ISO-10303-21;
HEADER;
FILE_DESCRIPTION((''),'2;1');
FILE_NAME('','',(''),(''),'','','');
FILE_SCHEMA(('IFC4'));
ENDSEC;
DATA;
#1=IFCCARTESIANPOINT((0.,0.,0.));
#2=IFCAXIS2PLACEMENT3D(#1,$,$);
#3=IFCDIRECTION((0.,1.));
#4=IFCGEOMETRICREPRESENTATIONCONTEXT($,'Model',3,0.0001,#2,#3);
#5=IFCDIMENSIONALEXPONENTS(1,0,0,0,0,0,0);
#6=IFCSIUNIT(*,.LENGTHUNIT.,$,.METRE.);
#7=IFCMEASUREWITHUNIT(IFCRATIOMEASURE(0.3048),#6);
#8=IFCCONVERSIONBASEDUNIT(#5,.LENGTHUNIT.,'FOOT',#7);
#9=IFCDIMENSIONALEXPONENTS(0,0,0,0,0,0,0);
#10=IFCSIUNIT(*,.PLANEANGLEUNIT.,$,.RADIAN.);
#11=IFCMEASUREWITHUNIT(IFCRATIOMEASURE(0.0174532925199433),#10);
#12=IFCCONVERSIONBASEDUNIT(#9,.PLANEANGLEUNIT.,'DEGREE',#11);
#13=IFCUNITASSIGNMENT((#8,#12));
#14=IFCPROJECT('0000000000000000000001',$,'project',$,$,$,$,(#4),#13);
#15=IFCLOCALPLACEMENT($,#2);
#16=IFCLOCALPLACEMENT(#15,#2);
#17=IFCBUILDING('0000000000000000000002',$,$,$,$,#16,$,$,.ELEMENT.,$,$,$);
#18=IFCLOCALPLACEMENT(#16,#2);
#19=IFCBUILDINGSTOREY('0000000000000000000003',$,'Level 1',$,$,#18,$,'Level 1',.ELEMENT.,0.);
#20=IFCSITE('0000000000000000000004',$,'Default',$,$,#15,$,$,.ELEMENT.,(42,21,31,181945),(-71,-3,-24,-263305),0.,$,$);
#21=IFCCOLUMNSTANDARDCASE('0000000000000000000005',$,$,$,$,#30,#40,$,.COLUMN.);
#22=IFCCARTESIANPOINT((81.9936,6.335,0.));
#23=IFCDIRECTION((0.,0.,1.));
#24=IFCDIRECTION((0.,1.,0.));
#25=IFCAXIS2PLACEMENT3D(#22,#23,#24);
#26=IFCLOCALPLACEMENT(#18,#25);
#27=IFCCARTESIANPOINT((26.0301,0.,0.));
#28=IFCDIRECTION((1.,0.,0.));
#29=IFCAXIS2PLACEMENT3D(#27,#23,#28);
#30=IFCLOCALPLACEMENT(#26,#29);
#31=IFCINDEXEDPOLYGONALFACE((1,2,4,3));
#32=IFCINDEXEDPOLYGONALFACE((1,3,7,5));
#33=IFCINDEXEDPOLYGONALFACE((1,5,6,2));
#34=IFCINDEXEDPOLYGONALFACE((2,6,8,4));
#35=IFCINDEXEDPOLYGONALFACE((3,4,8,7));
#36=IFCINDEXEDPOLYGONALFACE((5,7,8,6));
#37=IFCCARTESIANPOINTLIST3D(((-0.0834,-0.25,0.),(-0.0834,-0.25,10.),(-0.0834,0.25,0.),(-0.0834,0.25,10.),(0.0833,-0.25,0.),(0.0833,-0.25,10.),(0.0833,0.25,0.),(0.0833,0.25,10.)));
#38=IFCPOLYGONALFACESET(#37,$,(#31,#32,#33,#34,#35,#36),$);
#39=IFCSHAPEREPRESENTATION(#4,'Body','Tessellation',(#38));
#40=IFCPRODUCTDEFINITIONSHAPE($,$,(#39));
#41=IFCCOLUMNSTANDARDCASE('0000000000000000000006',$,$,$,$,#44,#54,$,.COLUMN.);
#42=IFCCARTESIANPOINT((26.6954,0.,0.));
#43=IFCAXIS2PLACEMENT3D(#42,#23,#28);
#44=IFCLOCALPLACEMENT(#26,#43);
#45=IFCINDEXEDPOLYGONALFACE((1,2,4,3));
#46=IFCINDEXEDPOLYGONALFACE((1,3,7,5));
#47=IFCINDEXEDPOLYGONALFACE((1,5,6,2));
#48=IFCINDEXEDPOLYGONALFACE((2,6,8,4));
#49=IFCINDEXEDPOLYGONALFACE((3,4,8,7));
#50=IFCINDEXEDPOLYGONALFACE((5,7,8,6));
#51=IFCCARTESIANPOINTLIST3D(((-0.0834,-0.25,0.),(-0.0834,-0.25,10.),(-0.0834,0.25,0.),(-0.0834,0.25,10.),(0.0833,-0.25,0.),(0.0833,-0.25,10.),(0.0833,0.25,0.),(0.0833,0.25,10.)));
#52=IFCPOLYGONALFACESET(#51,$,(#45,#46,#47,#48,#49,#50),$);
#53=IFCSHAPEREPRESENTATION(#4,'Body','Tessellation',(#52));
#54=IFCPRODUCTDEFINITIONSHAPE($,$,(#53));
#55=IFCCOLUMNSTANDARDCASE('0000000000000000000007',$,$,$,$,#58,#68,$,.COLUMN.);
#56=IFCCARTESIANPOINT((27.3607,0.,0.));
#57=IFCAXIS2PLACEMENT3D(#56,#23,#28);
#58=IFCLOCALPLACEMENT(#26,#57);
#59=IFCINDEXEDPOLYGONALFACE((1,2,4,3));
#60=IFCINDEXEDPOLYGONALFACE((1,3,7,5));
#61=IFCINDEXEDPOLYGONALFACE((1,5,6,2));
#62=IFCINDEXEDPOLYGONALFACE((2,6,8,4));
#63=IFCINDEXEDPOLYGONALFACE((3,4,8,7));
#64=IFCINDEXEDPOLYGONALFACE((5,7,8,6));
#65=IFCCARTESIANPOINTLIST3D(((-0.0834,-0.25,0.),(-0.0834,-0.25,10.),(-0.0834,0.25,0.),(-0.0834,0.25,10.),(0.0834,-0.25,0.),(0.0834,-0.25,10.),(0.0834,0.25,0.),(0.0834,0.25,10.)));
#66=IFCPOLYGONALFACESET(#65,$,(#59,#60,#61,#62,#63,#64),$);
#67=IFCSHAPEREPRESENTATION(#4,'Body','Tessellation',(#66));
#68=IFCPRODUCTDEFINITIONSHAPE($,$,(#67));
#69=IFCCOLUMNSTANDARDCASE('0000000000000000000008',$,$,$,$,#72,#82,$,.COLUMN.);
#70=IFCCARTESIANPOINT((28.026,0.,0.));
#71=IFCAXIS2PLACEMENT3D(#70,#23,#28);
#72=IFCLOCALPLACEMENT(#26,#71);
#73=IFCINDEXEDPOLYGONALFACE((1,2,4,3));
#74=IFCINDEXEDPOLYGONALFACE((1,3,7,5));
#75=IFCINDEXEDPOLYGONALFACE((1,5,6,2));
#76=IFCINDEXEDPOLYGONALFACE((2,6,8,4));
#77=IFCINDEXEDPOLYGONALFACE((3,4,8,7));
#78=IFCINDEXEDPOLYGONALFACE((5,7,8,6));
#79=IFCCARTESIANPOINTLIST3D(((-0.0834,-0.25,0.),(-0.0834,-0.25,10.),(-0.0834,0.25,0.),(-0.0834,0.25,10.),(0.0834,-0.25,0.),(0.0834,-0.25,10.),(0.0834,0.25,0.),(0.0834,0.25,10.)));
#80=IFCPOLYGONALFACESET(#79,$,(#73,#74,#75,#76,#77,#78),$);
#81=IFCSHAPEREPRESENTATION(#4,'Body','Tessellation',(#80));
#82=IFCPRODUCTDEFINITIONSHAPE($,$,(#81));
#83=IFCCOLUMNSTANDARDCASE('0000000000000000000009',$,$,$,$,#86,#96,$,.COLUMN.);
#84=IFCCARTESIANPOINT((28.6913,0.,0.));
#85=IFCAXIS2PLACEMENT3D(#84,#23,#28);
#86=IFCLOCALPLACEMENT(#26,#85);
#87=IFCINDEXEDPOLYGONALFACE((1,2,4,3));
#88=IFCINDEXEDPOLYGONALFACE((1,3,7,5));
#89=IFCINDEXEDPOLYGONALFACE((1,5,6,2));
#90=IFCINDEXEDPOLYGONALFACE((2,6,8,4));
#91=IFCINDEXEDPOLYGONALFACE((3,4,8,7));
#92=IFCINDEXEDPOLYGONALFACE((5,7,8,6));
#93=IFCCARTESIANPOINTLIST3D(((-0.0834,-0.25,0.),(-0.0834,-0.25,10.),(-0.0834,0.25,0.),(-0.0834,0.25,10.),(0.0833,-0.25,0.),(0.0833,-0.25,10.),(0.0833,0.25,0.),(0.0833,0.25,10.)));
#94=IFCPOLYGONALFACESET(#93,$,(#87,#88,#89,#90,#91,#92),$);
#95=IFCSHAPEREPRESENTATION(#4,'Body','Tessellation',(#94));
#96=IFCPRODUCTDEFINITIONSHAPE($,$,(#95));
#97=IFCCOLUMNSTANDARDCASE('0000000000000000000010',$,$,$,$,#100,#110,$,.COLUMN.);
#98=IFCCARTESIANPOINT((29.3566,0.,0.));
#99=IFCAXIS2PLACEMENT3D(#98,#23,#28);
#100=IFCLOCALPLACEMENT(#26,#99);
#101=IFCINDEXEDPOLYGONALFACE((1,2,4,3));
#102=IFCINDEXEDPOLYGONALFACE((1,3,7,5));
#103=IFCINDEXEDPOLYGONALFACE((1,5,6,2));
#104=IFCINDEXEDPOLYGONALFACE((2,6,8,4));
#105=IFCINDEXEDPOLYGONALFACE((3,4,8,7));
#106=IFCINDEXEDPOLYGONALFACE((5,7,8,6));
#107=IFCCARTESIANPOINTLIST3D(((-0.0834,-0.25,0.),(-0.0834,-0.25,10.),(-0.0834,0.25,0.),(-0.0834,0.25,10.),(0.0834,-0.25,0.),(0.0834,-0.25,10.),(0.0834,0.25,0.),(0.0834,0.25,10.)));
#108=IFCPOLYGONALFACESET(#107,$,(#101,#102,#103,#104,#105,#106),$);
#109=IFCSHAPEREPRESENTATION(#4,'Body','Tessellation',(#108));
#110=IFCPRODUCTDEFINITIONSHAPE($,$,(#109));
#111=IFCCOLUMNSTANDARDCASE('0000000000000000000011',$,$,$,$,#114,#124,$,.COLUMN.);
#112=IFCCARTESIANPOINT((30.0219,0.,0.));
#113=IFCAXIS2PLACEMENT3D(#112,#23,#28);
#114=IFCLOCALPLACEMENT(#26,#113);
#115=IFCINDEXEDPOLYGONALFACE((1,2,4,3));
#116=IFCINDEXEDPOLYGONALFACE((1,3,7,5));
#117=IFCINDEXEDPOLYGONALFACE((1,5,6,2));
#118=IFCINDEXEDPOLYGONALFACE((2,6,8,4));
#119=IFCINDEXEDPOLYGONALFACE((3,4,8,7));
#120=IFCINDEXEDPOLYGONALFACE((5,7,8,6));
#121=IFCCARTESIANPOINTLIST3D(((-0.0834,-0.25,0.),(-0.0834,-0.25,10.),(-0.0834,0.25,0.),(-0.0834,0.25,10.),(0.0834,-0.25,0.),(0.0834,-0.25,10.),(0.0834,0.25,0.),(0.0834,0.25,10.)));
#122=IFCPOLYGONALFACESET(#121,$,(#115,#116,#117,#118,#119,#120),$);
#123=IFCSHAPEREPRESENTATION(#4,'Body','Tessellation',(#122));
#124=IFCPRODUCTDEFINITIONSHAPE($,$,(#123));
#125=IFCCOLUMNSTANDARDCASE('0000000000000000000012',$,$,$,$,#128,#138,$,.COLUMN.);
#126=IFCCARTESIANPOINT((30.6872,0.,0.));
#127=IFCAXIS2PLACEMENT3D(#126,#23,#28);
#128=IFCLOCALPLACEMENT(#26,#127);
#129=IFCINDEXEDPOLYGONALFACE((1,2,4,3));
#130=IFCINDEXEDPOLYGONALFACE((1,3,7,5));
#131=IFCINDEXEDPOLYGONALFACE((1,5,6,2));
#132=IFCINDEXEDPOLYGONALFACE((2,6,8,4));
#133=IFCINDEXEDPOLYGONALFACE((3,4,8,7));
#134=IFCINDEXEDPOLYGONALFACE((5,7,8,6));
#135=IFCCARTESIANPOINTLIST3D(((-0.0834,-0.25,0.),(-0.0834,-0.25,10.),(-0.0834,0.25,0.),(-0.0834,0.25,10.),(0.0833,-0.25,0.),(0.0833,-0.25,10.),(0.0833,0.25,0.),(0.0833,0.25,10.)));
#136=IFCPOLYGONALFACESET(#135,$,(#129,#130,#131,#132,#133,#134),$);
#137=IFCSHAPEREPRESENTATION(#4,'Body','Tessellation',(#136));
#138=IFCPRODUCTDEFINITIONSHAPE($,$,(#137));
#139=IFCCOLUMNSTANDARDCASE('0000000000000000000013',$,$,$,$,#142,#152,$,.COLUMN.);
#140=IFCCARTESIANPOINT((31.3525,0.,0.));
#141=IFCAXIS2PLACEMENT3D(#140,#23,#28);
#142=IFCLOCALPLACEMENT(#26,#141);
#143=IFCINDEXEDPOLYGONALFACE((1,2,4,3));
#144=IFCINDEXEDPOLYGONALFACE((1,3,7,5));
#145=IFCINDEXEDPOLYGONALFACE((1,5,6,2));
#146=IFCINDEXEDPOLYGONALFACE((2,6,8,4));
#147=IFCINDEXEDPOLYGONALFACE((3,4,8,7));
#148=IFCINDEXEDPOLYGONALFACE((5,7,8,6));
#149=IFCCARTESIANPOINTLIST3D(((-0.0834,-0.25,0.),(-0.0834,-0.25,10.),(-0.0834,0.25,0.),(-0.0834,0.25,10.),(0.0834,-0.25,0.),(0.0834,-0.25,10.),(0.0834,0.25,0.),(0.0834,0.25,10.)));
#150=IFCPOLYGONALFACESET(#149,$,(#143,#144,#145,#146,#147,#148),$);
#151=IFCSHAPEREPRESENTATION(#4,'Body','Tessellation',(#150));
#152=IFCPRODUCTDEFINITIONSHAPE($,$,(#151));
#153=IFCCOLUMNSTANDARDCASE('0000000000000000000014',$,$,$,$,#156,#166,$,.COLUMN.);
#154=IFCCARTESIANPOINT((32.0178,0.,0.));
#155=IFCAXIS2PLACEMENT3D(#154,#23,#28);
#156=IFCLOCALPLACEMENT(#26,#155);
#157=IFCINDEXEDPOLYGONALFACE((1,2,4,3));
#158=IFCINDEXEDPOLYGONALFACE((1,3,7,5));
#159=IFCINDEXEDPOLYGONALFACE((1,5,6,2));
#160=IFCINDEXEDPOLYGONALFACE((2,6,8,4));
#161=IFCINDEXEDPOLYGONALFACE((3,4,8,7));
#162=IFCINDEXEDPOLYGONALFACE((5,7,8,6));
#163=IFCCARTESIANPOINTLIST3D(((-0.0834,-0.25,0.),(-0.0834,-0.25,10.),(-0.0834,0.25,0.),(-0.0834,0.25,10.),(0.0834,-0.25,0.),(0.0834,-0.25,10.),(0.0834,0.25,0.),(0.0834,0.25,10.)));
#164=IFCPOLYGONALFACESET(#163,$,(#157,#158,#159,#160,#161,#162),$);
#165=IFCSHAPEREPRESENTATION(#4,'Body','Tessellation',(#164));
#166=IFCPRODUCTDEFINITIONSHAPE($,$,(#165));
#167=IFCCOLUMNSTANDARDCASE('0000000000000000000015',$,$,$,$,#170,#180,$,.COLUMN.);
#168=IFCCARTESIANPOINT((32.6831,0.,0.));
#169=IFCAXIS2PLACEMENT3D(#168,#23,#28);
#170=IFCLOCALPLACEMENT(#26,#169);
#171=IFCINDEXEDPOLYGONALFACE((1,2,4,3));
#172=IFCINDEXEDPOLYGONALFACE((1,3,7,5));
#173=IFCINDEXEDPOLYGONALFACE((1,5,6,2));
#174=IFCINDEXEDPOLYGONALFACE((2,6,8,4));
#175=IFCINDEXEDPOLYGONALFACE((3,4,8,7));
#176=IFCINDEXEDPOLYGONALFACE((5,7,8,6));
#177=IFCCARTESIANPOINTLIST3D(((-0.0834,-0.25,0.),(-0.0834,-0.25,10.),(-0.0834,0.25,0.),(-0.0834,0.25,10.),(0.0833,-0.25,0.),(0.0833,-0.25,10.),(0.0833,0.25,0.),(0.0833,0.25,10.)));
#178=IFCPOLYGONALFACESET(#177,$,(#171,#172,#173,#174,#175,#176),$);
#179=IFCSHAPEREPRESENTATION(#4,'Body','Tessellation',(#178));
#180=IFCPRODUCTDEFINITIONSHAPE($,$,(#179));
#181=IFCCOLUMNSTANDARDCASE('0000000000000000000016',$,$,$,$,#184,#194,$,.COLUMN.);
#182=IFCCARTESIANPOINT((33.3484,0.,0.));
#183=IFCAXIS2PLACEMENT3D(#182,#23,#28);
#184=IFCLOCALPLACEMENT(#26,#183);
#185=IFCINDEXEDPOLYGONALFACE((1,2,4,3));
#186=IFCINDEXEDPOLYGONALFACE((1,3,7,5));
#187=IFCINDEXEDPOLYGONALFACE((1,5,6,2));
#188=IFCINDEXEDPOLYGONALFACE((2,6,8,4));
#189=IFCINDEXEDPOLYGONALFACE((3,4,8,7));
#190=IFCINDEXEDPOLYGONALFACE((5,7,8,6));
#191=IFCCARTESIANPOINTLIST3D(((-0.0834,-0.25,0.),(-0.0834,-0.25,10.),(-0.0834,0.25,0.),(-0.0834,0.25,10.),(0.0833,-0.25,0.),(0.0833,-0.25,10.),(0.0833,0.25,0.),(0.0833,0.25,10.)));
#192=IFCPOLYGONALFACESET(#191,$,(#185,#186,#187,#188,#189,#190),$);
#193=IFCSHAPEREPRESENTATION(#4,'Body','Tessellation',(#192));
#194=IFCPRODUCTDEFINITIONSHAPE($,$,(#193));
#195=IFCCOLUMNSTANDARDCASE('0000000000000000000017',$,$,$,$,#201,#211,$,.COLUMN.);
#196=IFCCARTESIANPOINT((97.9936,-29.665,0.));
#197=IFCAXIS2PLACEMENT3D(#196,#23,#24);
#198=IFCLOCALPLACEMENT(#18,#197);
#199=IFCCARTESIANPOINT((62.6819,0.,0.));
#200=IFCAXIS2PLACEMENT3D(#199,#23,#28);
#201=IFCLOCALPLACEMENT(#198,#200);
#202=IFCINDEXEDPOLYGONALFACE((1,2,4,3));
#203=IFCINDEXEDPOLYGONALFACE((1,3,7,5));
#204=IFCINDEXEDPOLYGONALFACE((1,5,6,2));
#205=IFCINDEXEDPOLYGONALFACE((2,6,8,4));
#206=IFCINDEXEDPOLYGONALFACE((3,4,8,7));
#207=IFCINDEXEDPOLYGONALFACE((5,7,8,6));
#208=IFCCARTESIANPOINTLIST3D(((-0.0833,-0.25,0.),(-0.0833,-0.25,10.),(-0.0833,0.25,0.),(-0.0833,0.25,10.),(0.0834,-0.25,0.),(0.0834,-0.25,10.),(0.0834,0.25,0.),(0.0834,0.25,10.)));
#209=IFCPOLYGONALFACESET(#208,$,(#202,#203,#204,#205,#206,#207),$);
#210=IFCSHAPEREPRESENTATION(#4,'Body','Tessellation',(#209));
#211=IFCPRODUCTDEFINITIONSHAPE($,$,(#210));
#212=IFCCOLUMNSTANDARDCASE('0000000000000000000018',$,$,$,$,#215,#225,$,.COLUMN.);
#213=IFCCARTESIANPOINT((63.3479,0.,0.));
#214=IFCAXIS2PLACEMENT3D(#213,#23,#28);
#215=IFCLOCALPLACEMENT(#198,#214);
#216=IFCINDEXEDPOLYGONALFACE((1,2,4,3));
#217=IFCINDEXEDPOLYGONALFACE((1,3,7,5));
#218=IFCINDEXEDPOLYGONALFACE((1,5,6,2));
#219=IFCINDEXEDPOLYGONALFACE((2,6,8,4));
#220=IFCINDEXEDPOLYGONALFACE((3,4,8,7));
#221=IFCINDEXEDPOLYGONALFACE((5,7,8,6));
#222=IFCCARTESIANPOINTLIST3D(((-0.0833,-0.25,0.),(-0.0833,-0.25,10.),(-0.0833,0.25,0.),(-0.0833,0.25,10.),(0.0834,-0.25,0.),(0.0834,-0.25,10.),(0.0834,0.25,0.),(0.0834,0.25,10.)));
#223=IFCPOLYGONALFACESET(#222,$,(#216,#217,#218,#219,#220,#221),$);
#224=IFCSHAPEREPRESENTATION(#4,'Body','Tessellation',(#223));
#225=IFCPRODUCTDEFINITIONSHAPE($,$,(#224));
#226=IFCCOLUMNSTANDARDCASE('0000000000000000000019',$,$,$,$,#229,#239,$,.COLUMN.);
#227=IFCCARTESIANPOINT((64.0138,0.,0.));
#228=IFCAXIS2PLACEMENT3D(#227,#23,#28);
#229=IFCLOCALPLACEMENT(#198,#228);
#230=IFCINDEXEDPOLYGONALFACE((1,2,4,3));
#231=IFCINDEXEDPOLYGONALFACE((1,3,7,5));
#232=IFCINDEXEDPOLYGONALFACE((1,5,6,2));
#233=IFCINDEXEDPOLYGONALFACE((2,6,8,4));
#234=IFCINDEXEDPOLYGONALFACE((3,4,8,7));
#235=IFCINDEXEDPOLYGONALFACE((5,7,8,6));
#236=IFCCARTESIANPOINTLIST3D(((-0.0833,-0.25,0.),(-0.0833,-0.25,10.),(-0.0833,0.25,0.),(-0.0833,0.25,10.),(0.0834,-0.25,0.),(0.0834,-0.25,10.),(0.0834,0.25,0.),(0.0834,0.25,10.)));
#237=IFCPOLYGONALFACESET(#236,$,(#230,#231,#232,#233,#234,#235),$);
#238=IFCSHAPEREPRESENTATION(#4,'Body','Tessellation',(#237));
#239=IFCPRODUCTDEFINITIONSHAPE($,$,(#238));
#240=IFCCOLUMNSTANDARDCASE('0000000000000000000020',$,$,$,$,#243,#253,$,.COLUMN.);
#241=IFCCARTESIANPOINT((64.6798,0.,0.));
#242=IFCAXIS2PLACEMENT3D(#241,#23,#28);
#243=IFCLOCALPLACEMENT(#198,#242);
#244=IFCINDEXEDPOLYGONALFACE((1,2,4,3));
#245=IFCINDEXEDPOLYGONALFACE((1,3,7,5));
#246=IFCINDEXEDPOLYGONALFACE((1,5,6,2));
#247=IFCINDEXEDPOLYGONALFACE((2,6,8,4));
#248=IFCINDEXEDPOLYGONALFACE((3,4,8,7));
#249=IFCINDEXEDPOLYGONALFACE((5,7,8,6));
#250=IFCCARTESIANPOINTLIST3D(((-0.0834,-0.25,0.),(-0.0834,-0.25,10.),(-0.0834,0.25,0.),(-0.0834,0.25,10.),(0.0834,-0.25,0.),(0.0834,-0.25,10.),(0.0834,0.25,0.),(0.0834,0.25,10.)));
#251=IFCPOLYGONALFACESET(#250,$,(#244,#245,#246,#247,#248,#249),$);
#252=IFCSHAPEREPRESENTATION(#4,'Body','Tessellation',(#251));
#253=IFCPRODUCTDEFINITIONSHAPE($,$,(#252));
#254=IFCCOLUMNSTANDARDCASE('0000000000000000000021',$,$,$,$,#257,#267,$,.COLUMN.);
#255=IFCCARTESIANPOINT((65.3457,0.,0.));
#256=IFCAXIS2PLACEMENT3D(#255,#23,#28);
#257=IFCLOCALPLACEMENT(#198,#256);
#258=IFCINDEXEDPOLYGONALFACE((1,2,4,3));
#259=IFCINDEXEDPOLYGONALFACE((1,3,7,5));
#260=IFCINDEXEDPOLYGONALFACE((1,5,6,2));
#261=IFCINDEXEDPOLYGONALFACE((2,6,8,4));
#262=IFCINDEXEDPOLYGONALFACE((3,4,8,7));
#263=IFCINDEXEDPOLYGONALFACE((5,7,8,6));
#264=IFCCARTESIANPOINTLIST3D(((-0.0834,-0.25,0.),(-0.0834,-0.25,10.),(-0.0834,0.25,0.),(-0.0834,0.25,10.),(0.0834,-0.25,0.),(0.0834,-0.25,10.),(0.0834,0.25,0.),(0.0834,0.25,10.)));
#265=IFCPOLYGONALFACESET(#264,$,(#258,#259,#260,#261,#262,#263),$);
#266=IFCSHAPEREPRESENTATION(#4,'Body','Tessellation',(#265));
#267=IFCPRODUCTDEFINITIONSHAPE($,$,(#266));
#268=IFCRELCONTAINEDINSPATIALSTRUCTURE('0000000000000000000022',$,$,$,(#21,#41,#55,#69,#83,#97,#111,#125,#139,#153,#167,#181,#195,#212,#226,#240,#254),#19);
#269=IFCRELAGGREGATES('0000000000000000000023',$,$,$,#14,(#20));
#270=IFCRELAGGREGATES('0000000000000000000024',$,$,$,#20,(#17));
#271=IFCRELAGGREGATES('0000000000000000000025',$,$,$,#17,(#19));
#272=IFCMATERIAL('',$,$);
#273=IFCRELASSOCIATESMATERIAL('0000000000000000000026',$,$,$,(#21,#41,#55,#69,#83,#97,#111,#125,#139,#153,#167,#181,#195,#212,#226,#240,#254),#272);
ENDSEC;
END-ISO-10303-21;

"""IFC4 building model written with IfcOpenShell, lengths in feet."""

from ifc_helpers import new_model, entity, si_unit, converted_unit, direction, frame, origin, place, context, project, spatial, rectangle, extrude, material, element, save


model = new_model("IFC4")

# Units and contexts
model_context = context("Model", 3, precision=0.0001, world=origin(), true_north=direction((0.0, 1.0)))
ifc_project = project(units=[converted_unit("LENGTHUNIT", "FOOT", entity("IfcRatioMeasure", 0.3048), si_unit("LENGTHUNIT", "METRE"), dimensions=[1, 0, 0, 0, 0, 0, 0]), converted_unit("PLANEANGLEUNIT", "DEGREE", entity("IfcRatioMeasure", 0.0174532925199433), si_unit("PLANEANGLEUNIT", "RADIAN"), dimensions=[0, 0, 0, 0, 0, 0, 0])], contexts=[model_context])

# Site, building, storey
site_placement = place(None, origin())
site = spatial("IfcSite", under=ifc_project, at=site_placement, Name="Default", CompositionType="ELEMENT", RefLatitude=(42, 21, 31, 181945), RefLongitude=(-71, -3, -24, -263305), RefElevation=0.0)
building_placement = place(site_placement, origin())
building = spatial("IfcBuilding", under=site, at=building_placement, CompositionType="ELEMENT")
storey_placement = place(building_placement, origin())
storey = spatial("IfcBuildingStorey", under=building, at=storey_placement, Name="Level 1", LongName="Level 1", CompositionType="ELEMENT", Elevation=0.0)

# Columns
ifc_material = material(Name="")
placement_1 = place(storey_placement, frame((81.9936, 6.335, 0.0), z_axis=(0.0, 0.0, 1.0), x_axis=(0.0, 1.0, 0.0)))
for number, where, z_axis, x_axis in (
    (1, (26.0301, 0.0, 0.0), (0.0, 0.0, 1.0), (1.0, 0.0, 0.0)),
    (2, (26.6954, 0.0, 0.0), (0.0, 0.0, 1.0), (1.0, 0.0, 0.0)),
    (3, (27.3607, 0.0, 0.0), (0.0, 0.0, 1.0), (1.0, 0.0, 0.0)),
    (4, (28.026, 0.0, 0.0), (0.0, 0.0, 1.0), (1.0, 0.0, 0.0)),
    (5, (28.6913, 0.0, 0.0), (0.0, 0.0, 1.0), (1.0, 0.0, 0.0)),
    (6, (29.3566, 0.0, 0.0), (0.0, 0.0, 1.0), (1.0, 0.0, 0.0)),
    (7, (30.0219, 0.0, 0.0), (0.0, 0.0, 1.0), (1.0, 0.0, 0.0)),
    (8, (30.6872, 0.0, 0.0), (0.0, 0.0, 1.0), (1.0, 0.0, 0.0)),
    (9, (31.3525, 0.0, 0.0), (0.0, 0.0, 1.0), (1.0, 0.0, 0.0)),
    (10, (32.0178, 0.0, 0.0), (0.0, 0.0, 1.0), (1.0, 0.0, 0.0)),
    (11, (32.6831, 0.0, 0.0), (0.0, 0.0, 1.0), (1.0, 0.0, 0.0)),
    (12, (33.3484, 0.0, 0.0), (0.0, 0.0, 1.0), (1.0, 0.0, 0.0)),
):
    element("IfcColumnStandardCase", number, at=place(placement_1, frame(where, z_axis=z_axis, x_axis=x_axis)), inside=storey, material=ifc_material, PredefinedType="COLUMN", context=model_context, shape_type="SweptSolid", body=[
        extrude(rectangle(XDim=0.1667, YDim=0.5), origin(), (0.0, 0.0, 1.0), 10.0),
    ])
placement_2 = place(storey_placement, frame((97.9936, -29.665, 0.0), z_axis=(0.0, 0.0, 1.0), x_axis=(0.0, 1.0, 0.0)))
for number, where, z_axis, x_axis in (
    (13, (62.6819, 0.0, 0.0), (0.0, 0.0, 1.0), (1.0, 0.0, 0.0)),
    (14, (63.3479, 0.0, 0.0), (0.0, 0.0, 1.0), (1.0, 0.0, 0.0)),
    (15, (64.0138, 0.0, 0.0), (0.0, 0.0, 1.0), (1.0, 0.0, 0.0)),
    (16, (64.6798, 0.0, 0.0), (0.0, 0.0, 1.0), (1.0, 0.0, 0.0)),
    (17, (65.3457, 0.0, 0.0), (0.0, 0.0, 1.0), (1.0, 0.0, 0.0)),
):
    element("IfcColumnStandardCase", number, at=place(placement_2, frame(where, z_axis=z_axis, x_axis=x_axis)), inside=storey, material=ifc_material, PredefinedType="COLUMN", context=model_context, shape_type="SweptSolid", body=[
        extrude(rectangle(XDim=0.1667, YDim=0.5), origin(), (0.0, 0.0, 1.0), 10.0),
    ])

save(model, "model.ifc")
